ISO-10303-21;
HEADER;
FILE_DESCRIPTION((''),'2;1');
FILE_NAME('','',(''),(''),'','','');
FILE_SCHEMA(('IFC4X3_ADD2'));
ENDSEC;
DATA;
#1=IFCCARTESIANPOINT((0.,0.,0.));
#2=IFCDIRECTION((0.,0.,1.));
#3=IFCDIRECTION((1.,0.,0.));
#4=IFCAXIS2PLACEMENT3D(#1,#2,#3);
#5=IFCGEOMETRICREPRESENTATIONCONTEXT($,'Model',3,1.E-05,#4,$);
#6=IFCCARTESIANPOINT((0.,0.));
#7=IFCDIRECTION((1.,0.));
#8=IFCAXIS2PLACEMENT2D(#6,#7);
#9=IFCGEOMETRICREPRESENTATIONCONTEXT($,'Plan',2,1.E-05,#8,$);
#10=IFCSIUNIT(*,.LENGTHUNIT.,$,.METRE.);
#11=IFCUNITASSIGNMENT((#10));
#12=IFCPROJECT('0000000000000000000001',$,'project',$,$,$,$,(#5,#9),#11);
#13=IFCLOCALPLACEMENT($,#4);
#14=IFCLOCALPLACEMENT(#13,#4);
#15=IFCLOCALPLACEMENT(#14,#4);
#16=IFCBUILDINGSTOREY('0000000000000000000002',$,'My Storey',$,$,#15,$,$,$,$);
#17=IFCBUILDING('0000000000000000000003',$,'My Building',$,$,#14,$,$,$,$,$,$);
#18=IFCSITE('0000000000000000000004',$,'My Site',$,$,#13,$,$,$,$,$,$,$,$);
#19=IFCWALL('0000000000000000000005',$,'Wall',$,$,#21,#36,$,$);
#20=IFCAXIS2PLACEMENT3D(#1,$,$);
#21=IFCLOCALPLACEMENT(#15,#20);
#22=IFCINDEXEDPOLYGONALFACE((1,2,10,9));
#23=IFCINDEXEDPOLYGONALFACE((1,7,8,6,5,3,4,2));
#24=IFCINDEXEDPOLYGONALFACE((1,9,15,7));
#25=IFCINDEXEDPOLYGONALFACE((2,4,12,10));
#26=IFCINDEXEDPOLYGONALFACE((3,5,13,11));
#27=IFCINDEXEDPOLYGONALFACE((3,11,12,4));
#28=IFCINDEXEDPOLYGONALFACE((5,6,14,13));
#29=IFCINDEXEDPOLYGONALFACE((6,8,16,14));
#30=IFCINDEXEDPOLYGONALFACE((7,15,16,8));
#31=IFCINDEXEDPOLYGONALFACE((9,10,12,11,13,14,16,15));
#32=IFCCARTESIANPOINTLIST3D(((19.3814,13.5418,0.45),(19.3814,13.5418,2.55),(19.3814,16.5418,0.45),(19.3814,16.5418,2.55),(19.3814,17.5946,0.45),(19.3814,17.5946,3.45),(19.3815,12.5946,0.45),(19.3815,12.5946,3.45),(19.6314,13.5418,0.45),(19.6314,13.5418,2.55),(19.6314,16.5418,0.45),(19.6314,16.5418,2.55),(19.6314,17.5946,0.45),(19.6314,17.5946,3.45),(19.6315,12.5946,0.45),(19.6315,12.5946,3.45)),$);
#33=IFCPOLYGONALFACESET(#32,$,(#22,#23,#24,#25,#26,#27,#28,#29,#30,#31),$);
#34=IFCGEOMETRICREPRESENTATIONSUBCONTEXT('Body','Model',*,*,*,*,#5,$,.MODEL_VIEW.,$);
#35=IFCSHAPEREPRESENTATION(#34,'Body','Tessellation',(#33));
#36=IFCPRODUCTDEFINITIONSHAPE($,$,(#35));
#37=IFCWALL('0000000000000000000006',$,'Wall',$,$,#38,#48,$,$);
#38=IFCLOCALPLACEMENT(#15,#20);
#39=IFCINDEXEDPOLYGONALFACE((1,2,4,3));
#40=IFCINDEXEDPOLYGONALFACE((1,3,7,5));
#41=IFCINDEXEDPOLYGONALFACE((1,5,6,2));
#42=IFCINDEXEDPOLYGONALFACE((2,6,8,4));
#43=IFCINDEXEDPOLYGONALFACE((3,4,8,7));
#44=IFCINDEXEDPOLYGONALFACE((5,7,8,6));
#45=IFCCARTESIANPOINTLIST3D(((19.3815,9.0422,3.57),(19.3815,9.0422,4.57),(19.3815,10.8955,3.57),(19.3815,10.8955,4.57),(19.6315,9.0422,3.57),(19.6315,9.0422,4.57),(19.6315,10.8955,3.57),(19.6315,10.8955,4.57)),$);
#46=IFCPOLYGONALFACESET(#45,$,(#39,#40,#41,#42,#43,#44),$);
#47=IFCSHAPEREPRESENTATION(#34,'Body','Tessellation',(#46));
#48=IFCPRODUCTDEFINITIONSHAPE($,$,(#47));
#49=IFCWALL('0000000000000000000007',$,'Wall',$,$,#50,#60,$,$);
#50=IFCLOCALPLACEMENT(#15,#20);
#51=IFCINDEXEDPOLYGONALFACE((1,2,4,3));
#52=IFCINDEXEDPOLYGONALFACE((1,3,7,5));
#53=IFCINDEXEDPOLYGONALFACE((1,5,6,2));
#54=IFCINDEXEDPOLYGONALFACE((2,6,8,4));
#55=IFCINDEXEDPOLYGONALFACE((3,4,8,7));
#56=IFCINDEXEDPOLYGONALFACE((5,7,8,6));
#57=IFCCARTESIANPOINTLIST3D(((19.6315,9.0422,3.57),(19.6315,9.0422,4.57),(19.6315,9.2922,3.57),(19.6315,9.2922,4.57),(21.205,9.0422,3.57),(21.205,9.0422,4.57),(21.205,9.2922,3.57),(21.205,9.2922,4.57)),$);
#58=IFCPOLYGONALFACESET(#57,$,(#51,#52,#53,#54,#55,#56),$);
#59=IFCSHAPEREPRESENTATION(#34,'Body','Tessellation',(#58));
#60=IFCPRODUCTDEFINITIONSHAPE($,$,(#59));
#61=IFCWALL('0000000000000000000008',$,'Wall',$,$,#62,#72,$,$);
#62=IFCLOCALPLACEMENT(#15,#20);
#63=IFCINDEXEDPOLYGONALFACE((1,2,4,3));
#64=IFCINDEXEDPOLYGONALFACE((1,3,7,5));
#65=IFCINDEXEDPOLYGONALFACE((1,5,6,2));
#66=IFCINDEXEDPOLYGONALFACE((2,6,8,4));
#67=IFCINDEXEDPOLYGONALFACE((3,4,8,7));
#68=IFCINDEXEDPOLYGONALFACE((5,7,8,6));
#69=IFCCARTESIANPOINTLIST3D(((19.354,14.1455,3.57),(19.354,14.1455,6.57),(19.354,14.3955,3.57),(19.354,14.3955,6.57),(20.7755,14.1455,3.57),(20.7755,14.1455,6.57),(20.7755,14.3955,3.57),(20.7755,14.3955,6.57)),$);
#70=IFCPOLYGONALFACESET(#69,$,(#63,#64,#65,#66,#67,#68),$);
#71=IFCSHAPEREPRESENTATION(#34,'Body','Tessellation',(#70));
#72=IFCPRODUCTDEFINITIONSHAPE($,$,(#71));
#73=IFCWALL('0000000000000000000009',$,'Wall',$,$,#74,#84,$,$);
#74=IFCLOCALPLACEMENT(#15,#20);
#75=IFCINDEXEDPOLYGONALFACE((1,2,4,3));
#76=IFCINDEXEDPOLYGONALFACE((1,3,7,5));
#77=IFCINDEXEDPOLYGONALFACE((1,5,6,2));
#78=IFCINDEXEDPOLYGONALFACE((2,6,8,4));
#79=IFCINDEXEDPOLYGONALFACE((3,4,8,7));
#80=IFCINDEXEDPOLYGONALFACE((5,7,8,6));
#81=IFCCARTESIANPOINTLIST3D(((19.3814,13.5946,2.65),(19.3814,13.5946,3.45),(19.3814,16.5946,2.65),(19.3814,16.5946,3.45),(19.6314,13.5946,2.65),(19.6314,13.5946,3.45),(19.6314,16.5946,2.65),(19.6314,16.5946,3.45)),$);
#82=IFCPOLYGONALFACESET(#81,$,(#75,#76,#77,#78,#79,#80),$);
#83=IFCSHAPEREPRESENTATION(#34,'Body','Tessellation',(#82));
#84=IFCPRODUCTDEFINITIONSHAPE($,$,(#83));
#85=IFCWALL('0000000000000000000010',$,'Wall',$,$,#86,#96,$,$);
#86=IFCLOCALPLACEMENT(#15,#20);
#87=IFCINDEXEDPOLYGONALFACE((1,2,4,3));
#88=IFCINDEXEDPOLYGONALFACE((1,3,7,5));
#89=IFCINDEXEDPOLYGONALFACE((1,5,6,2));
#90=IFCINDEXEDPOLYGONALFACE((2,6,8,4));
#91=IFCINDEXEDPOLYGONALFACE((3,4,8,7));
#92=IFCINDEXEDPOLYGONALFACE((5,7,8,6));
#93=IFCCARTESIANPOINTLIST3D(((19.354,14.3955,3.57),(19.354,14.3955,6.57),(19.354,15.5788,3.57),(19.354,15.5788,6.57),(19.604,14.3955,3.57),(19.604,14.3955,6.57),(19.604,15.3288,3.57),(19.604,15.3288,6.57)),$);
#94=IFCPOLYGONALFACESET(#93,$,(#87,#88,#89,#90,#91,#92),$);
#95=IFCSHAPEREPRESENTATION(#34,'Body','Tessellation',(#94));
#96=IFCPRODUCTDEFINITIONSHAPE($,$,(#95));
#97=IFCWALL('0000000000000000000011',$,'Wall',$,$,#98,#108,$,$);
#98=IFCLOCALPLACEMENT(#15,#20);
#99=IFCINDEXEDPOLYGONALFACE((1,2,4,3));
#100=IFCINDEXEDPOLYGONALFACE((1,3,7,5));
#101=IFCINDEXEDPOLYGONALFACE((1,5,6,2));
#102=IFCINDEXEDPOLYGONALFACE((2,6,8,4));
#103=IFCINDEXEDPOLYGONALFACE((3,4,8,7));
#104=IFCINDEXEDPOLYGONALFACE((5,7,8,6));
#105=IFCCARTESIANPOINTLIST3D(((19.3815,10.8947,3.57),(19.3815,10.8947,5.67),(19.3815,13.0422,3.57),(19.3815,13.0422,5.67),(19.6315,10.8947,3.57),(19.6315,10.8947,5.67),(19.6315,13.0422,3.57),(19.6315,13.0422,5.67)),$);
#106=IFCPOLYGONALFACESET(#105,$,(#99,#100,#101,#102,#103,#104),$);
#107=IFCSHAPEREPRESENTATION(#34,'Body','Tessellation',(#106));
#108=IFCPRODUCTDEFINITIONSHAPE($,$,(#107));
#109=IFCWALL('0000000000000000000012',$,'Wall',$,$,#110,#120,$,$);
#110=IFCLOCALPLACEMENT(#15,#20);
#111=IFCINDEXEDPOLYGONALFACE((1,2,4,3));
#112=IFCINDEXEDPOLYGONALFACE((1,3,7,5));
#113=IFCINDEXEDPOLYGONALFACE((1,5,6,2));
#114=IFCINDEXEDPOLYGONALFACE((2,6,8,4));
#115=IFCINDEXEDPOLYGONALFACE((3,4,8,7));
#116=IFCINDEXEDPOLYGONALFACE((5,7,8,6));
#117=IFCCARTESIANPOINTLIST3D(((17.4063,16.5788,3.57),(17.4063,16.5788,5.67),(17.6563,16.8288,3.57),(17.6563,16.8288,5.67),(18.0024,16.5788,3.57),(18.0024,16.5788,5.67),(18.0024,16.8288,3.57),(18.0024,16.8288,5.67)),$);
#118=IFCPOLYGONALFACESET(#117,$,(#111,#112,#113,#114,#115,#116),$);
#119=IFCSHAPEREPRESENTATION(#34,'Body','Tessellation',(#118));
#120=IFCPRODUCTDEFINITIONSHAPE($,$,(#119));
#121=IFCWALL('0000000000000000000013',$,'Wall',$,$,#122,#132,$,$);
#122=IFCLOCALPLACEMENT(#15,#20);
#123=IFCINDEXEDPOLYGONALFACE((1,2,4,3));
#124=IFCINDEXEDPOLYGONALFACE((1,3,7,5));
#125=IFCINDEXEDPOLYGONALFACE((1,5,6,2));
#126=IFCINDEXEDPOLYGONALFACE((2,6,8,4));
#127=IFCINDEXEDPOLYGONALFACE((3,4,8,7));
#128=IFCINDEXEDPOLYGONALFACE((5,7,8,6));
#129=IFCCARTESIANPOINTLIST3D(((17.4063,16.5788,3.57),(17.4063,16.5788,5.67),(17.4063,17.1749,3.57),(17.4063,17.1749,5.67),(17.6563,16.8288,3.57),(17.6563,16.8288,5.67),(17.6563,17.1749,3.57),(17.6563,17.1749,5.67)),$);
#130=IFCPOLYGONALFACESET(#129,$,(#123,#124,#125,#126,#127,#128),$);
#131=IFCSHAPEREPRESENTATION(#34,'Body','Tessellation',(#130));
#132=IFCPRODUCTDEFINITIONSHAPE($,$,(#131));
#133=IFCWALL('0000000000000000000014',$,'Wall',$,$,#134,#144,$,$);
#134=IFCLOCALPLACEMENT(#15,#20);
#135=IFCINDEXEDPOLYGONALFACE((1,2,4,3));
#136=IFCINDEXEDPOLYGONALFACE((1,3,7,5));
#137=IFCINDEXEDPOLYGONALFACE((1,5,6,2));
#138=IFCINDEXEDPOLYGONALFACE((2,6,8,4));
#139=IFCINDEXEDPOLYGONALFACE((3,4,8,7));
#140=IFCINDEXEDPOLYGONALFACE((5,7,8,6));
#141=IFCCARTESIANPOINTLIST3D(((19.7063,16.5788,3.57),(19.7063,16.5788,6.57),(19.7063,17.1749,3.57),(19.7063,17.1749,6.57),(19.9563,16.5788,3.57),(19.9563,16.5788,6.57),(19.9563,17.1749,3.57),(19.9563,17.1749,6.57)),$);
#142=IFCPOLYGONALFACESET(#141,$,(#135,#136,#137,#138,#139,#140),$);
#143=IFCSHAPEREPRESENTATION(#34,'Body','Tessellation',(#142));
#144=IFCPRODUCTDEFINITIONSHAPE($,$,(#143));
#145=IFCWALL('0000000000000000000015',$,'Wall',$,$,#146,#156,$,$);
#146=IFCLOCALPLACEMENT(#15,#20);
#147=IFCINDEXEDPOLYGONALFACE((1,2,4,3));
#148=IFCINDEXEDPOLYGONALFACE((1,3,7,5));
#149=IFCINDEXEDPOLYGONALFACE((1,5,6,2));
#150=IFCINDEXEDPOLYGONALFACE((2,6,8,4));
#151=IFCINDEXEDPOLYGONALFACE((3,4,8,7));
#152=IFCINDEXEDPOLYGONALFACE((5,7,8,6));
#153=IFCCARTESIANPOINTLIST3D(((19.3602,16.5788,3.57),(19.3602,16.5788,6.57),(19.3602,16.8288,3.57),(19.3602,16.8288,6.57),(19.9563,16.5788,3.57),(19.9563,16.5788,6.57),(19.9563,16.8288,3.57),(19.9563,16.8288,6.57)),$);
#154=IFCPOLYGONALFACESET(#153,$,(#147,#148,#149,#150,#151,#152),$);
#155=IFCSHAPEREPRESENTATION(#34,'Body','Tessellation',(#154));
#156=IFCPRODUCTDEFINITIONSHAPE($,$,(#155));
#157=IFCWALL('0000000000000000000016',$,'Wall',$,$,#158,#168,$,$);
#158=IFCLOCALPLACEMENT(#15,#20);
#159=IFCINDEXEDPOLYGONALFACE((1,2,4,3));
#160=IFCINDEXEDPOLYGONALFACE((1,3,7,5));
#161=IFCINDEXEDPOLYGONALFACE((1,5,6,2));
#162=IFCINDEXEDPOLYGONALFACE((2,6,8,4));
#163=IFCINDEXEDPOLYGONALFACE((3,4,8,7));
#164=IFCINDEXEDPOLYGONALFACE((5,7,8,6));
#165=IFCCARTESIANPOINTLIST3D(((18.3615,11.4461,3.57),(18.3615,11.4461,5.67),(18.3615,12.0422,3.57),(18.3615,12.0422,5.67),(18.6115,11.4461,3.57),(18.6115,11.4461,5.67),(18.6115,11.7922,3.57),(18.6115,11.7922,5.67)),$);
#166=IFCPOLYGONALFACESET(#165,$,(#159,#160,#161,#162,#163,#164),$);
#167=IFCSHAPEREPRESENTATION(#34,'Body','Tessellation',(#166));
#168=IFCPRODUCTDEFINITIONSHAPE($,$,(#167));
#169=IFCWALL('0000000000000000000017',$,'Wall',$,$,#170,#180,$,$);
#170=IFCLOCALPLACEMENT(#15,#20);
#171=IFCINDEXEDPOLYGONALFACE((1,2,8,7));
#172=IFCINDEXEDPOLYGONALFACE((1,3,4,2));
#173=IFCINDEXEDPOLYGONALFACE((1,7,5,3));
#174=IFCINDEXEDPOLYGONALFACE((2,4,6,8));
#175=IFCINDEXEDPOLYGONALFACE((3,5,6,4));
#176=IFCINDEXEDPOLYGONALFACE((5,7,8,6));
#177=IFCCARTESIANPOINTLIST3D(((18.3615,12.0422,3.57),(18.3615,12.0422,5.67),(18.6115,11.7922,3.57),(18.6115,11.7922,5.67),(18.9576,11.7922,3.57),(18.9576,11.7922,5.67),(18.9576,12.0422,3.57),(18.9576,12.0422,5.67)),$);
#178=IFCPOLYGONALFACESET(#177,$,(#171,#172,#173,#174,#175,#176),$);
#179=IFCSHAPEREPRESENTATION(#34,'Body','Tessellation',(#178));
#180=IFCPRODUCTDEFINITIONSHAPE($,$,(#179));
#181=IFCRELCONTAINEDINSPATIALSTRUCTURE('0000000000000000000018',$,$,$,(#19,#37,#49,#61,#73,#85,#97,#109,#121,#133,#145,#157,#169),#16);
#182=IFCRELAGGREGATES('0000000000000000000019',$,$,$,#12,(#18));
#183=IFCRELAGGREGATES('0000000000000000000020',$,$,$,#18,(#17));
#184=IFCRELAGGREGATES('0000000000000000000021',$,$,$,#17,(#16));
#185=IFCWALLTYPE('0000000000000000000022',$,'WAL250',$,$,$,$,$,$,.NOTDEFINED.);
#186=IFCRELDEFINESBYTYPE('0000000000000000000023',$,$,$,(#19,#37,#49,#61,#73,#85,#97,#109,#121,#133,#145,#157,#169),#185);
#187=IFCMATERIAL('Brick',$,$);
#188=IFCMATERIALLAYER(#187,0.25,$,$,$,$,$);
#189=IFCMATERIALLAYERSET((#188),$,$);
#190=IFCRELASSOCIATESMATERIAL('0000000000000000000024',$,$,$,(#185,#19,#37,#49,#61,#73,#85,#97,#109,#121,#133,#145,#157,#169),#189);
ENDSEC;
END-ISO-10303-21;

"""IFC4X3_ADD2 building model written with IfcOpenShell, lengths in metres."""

from ifc_helpers import new_model, si_unit, frame, origin_with_axes, origin_2d_with_axis, place, context, subcontext, project, spatial, line, indexed_curve, outline, extrude, source, transform, mapped, material, layer, layer_set, layer_usage, type_object, element, save


model = new_model("IFC4X3_ADD2")

# Units and contexts
model_context = context("Model", 3, precision=1e-05, world=origin_with_axes())
plan_context = context("Plan", 2, precision=1e-05, world=origin_2d_with_axis())
body_context = subcontext(model_context, "Body", "Model", "MODEL_VIEW")
ifc_project = project(units=[si_unit("LENGTHUNIT", "METRE")], contexts=[model_context, plan_context])

# Site, building, storey
site_placement = place(None, origin_with_axes())
site = spatial("IfcSite", under=ifc_project, at=site_placement, Name="My Site")
building_placement = place(site_placement, origin_with_axes())
building = spatial("IfcBuilding", under=site, at=building_placement, Name="My Building")
storey_placement = place(building_placement, origin_with_axes())
storey = spatial("IfcBuildingStorey", under=building, at=storey_placement, Name="My Storey")

# Wall, opening
ifc_material_1 = material(Name="Brick")
ifc_layer_1 = layer(ifc_material_1, 0.25)
ifc_layer_set_1 = layer_set([ifc_layer_1])
ifc_layer_usage_1 = layer_usage(ifc_layer_set_1, "AXIS2", "POSITIVE", 0.0)
wall_type = type_object("IfcWallType", Name="WAL250", PredefinedType="NOTDEFINED", material=ifc_layer_set_1)
wall_1_placement = place(storey_placement, frame((19.6315, 12.5946, 0.45), z_axis=(0.0, 0.0, 1.0), x_axis=(-0.000006, 1.0, 0.0)))
wall_1 = element("IfcWall", 1, at=wall_1_placement, inside=storey, type_object=wall_type, material=ifc_layer_usage_1, Name="Wall", context=body_context, shape_type="SweptSolid", body=[
    extrude(outline(indexed_curve([(0.0, 0.0), (0.0, 0.25), (5.0, 0.25), (5.0, 0.0)], segments=[line(1, 2, 3, 4, 1)])), origin_with_axes(), (0.0, 0.0, 1.0), 3.0),
])
shared_shape = source(origin_with_axes(), body_context, "Body", "SweptSolid", [
    extrude(outline(indexed_curve([(0.0, 2.1), (3.0, 2.1), (3.0, 0.0), (0.0, 0.0), (0.0, 2.1)])), frame((0.0, -0.6, 0.0), z_axis=(0.0, -1.0, 0.0), x_axis=(1.0, 0.0, 0.0)), (0.0, 0.0, -1.0), 1.2),
])
opening_placement = place(wall_1_placement, frame((3.9472, 0.25, 0.0), z_axis=(0.0, 0.0, 1.0), x_axis=(-1.0, 0.0, 0.0)))
element("IfcOpeningElement", 2, at=opening_placement, cuts=wall_1, PredefinedType="OPENING", context=body_context, shape_type="MappedRepresentation", body=[
    mapped(shared_shape, transform((0.0, 0.0, 0.0), x_axis=(1.0, 0.0, 0.0), y_axis=(0.0, 1.0, 0.0), z_axis=(0.0, 0.0, 1.0), scale=1.0)),
])

# Walls
ifc_layer_usage_2 = layer_usage(ifc_layer_set_1, "AXIS2", "NEGATIVE", 0.0)
wall_2_placement = place(storey_placement, frame((19.3815, 9.0422, 3.57), z_axis=(0.0, 0.0, 1.0), x_axis=(0.0, 1.0, 0.0)))
element("IfcWall", 3, at=wall_2_placement, inside=storey, type_object=wall_type, material=ifc_layer_usage_2, Name="Wall", context=body_context, shape_type="SweptSolid", body=[
    extrude(outline(indexed_curve([(0.0, -0.25), (0.0, 0.0), (1.8532, 0.0), (1.8532, -0.25)], segments=[line(1, 2, 3, 4, 1)])), origin_with_axes(), (0.0, 0.0, 1.0), 1.0),
])
ifc_layer_usage_3 = layer_usage(ifc_layer_set_1, "AXIS2", "POSITIVE", 0.0)
wall_3_placement = place(storey_placement, frame((19.6315, 9.0422, 3.57), z_axis=(0.0, 0.0, 1.0), x_axis=(1.0, 0.000006, 0.0)))
element("IfcWall", 4, at=wall_3_placement, inside=storey, type_object=wall_type, material=ifc_layer_usage_3, Name="Wall", context=body_context, shape_type="SweptSolid", body=[
    extrude(outline(indexed_curve([(0.0, 0.0), (0.0, 0.25), (1.5735, 0.25), (1.5735, 0.0)], segments=[line(1, 2, 3, 4, 1)])), origin_with_axes(), (0.0, 0.0, 1.0), 1.0),
])
ifc_layer_usage_4 = layer_usage(ifc_layer_set_1, "AXIS2", "POSITIVE", 0.0)
wall_4_placement = place(storey_placement, frame((19.354, 14.1455, 3.57), z_axis=(0.0, 0.0, 1.0), x_axis=(1.0, 0.000006, 0.0)))
element("IfcWall", 5, at=wall_4_placement, inside=storey, type_object=wall_type, material=ifc_layer_usage_4, Name="Wall", context=body_context, shape_type="SweptSolid", body=[
    extrude(outline(indexed_curve([(0.0, 0.0), (0.0, 0.25), (1.4216, 0.25), (1.4216, 0.0)], segments=[line(1, 2, 3, 4, 1)])), origin_with_axes(), (0.0, 0.0, 1.0), 3.0),
])
ifc_layer_usage_5 = layer_usage(ifc_layer_set_1, "AXIS2", "POSITIVE", 0.0)
wall_5_placement = place(storey_placement, frame((19.6314, 13.5946, 2.65), z_axis=(0.0, 0.0, 1.0), x_axis=(-0.000006, 1.0, 0.0)))
element("IfcWall", 6, at=wall_5_placement, inside=storey, type_object=wall_type, material=ifc_layer_usage_5, Name="Wall", context=body_context, shape_type="SweptSolid", body=[
    extrude(outline(indexed_curve([(0.0, 0.0), (0.0, 0.25), (3.0, 0.25), (3.0, 0.0)], segments=[line(1, 2, 3, 4, 1)])), origin_with_axes(), (0.0, 0.0, 1.0), 0.8),
])
ifc_layer_usage_6 = layer_usage(ifc_layer_set_1, "AXIS2", "POSITIVE", 0.0)
wall_6_placement = place(storey_placement, frame((19.604, 14.1455, 3.57), z_axis=(0.0, 0.0, 1.0), x_axis=(-0.000006, 1.0, 0.0)))
element("IfcWall", 7, at=wall_6_placement, inside=storey, type_object=wall_type, material=ifc_layer_usage_6, Name="Wall", context=body_context, shape_type="SweptSolid", body=[
    extrude(outline(indexed_curve([(0.25, 0.0), (0.25, 0.25), (1.4333, 0.25), (1.1833, 0.0)], segments=[line(1, 2, 3, 4, 1)])), origin_with_axes(), (0.0, 0.0, 1.0), 3.0),
])
ifc_layer_usage_7 = layer_usage(ifc_layer_set_1, "AXIS2", "NEGATIVE", 0.0)
wall_7_placement = place(storey_placement, frame((19.3815, 10.8947, 3.57), z_axis=(0.0, 0.0, 1.0), x_axis=(0.0, 1.0, 0.0)))
element("IfcWall", 8, at=wall_7_placement, inside=storey, type_object=wall_type, material=ifc_layer_usage_7, Name="Wall", context=body_context, shape_type="SweptSolid", body=[
    extrude(outline(indexed_curve([(0.0, -0.25), (0.0, 0.0), (2.1475, 0.0), (2.1475, -0.25)], segments=[line(1, 2, 3, 4, 1)])), origin_with_axes(), (0.0, 0.0, 1.0), 2.1),
])
ifc_layer_usage_8 = layer_usage(ifc_layer_set_1, "AXIS2", "POSITIVE", 0.0)
wall_8_placement = place(storey_placement, frame((17.4063, 16.5788, 3.57), z_axis=(0.0, 0.0, 1.0), x_axis=(1.0, 0.000006, 0.0)))
element("IfcWall", 9, at=wall_8_placement, inside=storey, type_object=wall_type, material=ifc_layer_usage_8, Name="Wall", context=body_context, shape_type="SweptSolid", body=[
    extrude(outline(indexed_curve([(0.0, 0.0), (0.25, 0.25), (0.5961, 0.25), (0.5961, 0.0)], segments=[line(1, 2, 3, 4, 1)])), origin_with_axes(), (0.0, 0.0, 1.0), 2.1),
])
ifc_layer_usage_9 = layer_usage(ifc_layer_set_1, "AXIS2", "NEGATIVE", 0.0)
wall_9_placement = place(storey_placement, frame((17.4063, 16.5788, 3.57), z_axis=(0.0, 0.0, 1.0), x_axis=(-0.000006, 1.0, 0.0)))
element("IfcWall", 10, at=wall_9_placement, inside=storey, type_object=wall_type, material=ifc_layer_usage_9, Name="Wall", context=body_context, shape_type="SweptSolid", body=[
    extrude(outline(indexed_curve([(0.25, -0.25), (0.0, 0.0), (0.5961, 0.0), (0.5961, -0.25)], segments=[line(1, 2, 3, 4, 1)])), origin_with_axes(), (0.0, 0.0, 1.0), 2.1),
])
ifc_layer_usage_10 = layer_usage(ifc_layer_set_1, "AXIS2", "POSITIVE", 0.0)
wall_10_placement = place(storey_placement, frame((19.9563, 16.5788, 3.57), z_axis=(0.0, 0.0, 1.0), x_axis=(-0.000006, 1.0, 0.0)))
element("IfcWall", 11, at=wall_10_placement, inside=storey, type_object=wall_type, material=ifc_layer_usage_10, Name="Wall", context=body_context, shape_type="SweptSolid", body=[
    extrude(outline(indexed_curve([(0.0, 0.0), (0.0, 0.25), (0.5961, 0.25), (0.5961, 0.0)], segments=[line(1, 2, 3, 4, 1)])), origin_with_axes(), (0.0, 0.0, 1.0), 3.0),
])
ifc_layer_usage_11 = layer_usage(ifc_layer_set_1, "AXIS2", "NEGATIVE", 0.0)
wall_11_placement = place(storey_placement, frame((19.9563, 16.5788, 3.57), z_axis=(0.0, 0.0, 1.0), x_axis=(-1.0, -0.000005, 0.0)))
element("IfcWall", 12, at=wall_11_placement, inside=storey, type_object=wall_type, material=ifc_layer_usage_11, Name="Wall", context=body_context, shape_type="SweptSolid", body=[
    extrude(outline(indexed_curve([(0.0, -0.25), (0.0, 0.0), (0.5961, 0.0), (0.5961, -0.25)], segments=[line(1, 2, 3, 4, 1)])), origin_with_axes(), (0.0, 0.0, 1.0), 3.0),
])
ifc_layer_usage_12 = layer_usage(ifc_layer_set_1, "AXIS2", "POSITIVE", 0.0)
wall_12_placement = place(storey_placement, frame((18.3615, 12.0422, 3.57), z_axis=(0.0, 0.0, 1.0), x_axis=(0.000006, -1.0, 0.0)))
element("IfcWall", 13, at=wall_12_placement, inside=storey, type_object=wall_type, material=ifc_layer_usage_12, Name="Wall", context=body_context, shape_type="SweptSolid", body=[
    extrude(outline(indexed_curve([(0.0, 0.0), (0.25, 0.25), (0.5961, 0.25), (0.5961, 0.0)], segments=[line(1, 2, 3, 4, 1)])), origin_with_axes(), (0.0, 0.0, 1.0), 2.1),
])
ifc_layer_usage_13 = layer_usage(ifc_layer_set_1, "AXIS2", "NEGATIVE", 0.0)
wall_13_placement = place(storey_placement, frame((18.3615, 12.0422, 3.57), z_axis=(0.0, 0.0, 1.0), x_axis=(1.0, 0.000005, 0.0)))
element("IfcWall", 14, at=wall_13_placement, inside=storey, type_object=wall_type, material=ifc_layer_usage_13, Name="Wall", context=body_context, shape_type="SweptSolid", body=[
    extrude(outline(indexed_curve([(0.25, -0.25), (0.0, 0.0), (0.5961, 0.0), (0.5961, -0.25)], segments=[line(1, 2, 3, 4, 1)])), origin_with_axes(), (0.0, 0.0, 1.0), 2.1),
])

save(model, "model.ifc")
